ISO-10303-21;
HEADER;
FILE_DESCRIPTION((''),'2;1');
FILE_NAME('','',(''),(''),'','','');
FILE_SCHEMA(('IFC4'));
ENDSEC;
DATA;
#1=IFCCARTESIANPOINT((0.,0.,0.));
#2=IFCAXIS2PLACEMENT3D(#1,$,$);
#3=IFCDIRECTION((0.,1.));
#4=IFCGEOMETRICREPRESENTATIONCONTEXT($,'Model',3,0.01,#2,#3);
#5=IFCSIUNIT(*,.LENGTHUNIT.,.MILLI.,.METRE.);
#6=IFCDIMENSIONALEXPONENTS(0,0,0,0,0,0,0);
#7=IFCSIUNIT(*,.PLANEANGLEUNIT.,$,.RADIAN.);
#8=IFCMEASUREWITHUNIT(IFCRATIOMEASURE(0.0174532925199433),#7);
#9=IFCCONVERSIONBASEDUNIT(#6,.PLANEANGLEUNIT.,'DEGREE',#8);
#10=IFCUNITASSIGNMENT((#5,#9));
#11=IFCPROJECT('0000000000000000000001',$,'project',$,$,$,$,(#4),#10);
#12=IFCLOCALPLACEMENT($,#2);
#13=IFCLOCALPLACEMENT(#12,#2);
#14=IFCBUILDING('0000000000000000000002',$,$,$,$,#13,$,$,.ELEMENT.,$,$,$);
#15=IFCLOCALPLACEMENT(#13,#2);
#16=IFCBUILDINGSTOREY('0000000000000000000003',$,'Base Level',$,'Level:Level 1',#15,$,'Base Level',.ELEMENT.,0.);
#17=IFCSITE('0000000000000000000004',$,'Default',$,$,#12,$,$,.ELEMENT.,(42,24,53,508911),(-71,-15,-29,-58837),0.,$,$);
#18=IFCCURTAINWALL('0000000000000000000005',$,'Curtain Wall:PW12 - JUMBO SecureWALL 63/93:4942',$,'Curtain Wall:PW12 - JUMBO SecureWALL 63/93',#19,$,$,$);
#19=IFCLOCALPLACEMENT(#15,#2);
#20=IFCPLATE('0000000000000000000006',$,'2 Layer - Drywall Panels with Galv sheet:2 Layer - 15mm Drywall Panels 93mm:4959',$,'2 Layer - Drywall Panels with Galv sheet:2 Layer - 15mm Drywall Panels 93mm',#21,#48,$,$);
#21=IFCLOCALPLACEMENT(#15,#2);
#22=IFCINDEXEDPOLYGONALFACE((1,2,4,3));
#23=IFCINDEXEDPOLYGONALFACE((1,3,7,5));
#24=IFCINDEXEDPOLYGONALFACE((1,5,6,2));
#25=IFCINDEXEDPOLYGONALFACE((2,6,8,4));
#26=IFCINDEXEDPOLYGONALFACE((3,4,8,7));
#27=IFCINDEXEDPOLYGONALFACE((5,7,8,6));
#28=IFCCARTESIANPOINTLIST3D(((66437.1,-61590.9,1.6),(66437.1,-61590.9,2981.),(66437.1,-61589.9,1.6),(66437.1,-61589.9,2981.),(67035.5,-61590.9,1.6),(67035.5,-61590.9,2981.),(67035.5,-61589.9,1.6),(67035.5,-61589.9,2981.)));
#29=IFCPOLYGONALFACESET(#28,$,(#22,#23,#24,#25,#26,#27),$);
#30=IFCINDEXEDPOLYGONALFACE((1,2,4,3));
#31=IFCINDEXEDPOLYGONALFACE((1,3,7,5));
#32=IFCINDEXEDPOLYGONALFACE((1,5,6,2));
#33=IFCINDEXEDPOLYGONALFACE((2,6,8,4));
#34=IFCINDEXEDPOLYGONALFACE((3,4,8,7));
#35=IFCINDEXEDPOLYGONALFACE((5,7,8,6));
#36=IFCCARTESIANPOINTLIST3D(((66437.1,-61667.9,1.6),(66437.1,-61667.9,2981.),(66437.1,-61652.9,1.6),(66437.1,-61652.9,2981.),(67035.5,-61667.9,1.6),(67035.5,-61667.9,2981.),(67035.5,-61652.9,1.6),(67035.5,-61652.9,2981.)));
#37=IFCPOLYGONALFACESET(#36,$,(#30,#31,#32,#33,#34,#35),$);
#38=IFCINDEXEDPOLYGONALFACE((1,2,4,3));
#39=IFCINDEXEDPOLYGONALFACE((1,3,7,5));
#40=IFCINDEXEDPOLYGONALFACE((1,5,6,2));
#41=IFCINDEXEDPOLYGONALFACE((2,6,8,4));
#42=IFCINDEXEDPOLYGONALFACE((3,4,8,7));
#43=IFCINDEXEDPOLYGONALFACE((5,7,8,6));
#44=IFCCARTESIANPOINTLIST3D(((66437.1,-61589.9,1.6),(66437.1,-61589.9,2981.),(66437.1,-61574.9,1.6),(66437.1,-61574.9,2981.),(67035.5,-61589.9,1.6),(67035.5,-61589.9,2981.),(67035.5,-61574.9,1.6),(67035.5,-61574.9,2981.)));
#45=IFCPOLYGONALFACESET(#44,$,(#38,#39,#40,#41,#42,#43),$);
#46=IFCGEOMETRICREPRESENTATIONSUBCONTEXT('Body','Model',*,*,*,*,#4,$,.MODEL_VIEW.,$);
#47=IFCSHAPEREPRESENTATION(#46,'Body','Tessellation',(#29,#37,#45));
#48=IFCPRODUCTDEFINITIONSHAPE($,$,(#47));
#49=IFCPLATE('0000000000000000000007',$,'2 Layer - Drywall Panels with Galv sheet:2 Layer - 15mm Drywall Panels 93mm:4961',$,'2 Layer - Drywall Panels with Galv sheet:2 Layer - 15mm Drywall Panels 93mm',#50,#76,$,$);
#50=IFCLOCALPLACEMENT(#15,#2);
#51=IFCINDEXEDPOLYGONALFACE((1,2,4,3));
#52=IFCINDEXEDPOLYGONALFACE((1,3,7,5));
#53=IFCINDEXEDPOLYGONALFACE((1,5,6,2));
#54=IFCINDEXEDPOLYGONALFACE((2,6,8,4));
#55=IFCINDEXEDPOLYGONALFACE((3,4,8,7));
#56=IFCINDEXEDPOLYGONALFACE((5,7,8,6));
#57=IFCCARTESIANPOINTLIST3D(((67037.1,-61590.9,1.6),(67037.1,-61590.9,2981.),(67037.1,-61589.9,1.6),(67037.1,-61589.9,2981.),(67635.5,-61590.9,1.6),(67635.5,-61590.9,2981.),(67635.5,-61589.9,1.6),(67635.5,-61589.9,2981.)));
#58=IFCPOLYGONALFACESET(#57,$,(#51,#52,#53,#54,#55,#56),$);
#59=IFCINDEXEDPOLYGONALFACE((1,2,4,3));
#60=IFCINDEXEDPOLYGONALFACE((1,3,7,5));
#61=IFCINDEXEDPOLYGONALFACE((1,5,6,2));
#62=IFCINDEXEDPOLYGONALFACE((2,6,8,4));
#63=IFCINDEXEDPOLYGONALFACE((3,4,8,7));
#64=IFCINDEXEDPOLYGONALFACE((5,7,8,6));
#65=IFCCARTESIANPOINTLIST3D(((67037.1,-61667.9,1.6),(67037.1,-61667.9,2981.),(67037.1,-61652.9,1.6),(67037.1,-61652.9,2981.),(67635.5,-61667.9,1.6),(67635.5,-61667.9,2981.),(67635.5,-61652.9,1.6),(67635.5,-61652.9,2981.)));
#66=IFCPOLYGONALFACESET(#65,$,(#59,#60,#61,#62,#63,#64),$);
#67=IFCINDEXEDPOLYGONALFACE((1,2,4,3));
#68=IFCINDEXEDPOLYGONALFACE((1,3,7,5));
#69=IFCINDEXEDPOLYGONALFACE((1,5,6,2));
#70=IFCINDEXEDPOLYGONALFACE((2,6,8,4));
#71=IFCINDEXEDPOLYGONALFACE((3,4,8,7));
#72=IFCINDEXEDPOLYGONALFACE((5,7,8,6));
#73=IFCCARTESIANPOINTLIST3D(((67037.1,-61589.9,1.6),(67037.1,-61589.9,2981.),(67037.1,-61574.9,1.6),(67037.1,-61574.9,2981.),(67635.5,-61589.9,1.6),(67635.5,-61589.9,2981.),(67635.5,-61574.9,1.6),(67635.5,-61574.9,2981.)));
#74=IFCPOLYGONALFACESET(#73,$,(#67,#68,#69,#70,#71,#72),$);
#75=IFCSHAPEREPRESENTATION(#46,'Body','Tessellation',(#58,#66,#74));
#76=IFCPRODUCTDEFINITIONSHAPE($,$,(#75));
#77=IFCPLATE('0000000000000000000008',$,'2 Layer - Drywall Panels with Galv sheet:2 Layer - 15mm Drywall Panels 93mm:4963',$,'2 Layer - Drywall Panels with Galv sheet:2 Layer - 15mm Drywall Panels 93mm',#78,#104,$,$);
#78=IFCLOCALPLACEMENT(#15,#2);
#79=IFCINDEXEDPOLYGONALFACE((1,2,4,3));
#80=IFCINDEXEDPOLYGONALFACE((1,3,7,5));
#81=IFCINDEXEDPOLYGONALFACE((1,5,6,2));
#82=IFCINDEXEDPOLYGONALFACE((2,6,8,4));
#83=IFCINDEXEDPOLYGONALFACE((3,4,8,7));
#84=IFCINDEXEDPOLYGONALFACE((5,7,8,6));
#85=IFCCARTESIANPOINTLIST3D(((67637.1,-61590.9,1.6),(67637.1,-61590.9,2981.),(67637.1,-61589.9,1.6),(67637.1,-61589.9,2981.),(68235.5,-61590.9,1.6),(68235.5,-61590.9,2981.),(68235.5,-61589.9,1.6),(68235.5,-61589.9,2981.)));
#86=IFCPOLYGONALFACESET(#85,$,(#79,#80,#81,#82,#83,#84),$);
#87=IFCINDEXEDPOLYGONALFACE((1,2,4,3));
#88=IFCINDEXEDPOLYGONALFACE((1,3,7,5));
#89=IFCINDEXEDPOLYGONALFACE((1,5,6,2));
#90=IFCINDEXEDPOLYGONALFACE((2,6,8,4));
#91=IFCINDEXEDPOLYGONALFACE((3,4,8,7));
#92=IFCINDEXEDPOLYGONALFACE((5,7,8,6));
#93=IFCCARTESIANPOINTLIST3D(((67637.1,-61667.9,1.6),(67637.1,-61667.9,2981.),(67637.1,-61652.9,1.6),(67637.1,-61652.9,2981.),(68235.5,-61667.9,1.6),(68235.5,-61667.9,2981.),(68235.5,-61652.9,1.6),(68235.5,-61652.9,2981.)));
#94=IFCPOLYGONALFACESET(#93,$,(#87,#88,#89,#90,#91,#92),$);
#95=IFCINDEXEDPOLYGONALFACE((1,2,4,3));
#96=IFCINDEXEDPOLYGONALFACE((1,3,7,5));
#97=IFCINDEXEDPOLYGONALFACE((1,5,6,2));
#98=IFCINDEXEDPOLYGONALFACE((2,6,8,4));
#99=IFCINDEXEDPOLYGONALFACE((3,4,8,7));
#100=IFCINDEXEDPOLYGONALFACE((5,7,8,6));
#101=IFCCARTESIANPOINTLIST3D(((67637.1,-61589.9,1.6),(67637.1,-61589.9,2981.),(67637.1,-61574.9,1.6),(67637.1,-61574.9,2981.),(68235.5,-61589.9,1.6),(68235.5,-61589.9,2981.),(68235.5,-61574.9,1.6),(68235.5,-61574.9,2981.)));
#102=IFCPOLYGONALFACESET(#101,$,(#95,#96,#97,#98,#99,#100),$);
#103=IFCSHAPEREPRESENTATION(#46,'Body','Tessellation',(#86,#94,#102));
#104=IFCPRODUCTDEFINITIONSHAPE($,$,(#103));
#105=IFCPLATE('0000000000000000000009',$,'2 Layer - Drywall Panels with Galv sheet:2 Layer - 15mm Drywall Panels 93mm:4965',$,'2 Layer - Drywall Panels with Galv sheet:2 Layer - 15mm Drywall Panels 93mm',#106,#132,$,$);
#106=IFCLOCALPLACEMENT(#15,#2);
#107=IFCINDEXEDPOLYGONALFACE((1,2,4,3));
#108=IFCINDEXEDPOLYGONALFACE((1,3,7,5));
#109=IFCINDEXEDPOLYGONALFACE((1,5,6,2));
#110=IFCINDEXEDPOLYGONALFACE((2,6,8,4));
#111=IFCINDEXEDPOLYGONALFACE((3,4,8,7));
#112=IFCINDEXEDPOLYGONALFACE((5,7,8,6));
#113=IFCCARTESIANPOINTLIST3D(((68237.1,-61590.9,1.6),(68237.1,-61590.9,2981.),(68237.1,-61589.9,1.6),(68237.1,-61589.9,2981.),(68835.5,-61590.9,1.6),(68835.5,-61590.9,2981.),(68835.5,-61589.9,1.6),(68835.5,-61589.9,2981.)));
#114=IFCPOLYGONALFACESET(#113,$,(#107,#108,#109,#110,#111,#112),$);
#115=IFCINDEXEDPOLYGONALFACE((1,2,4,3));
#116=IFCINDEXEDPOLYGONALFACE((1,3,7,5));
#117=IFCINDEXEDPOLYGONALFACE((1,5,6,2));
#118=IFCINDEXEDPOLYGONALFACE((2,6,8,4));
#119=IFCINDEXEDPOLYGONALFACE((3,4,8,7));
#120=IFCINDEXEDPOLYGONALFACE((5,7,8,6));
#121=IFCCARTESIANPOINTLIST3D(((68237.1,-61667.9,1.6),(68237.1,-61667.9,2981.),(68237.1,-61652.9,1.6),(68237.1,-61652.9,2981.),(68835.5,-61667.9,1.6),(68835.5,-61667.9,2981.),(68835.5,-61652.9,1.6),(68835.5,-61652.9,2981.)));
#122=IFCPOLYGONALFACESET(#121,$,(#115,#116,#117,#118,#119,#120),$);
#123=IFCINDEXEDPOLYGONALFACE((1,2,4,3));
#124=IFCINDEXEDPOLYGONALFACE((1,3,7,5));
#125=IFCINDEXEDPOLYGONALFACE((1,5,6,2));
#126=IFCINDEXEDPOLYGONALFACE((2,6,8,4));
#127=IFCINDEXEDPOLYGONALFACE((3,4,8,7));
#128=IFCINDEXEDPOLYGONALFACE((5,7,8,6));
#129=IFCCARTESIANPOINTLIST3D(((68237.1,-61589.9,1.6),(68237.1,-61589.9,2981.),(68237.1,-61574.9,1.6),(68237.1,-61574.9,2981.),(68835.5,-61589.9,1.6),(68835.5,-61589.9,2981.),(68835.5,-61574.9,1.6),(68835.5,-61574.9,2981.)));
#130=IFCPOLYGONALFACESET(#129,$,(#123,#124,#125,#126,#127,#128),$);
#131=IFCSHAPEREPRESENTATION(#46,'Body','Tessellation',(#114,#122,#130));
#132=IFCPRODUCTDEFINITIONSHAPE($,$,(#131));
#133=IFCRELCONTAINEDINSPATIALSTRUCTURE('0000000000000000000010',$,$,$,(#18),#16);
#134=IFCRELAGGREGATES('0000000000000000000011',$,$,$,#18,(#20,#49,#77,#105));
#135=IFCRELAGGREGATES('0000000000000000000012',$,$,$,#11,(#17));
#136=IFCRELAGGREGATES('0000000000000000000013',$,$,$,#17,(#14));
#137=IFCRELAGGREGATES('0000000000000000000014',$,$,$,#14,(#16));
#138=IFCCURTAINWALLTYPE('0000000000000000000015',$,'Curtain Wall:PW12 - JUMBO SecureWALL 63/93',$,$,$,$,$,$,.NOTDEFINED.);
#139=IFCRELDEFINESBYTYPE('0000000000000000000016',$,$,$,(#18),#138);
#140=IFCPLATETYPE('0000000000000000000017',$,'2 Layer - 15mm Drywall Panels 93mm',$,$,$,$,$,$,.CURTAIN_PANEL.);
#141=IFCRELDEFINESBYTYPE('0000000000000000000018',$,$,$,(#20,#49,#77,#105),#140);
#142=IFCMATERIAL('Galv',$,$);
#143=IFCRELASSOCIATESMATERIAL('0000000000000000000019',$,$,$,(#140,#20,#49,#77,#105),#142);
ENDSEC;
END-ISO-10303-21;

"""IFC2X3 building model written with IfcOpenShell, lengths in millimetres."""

from ifc_helpers import new_model, entity, si_unit, converted_unit, direction, frame, frame_2d, origin, origin_2d_with_axis, place, context, subcontext, project, spatial, rectangle, extrude, source, transform, mapped, material, type_object, type_shapes, element, aggregate, save


model = new_model("IFC2X3")

# Units and contexts
model_context = context("Model", 3, precision=0.01, world=origin(), true_north=direction((0.0, 1.0)))
body_context = subcontext(model_context, "Body", "Model", "MODEL_VIEW")
ifc_project = project(units=[si_unit("LENGTHUNIT", "METRE", prefix="MILLI"), converted_unit("PLANEANGLEUNIT", "DEGREE", entity("IfcRatioMeasure", 0.0174532925199433), si_unit("PLANEANGLEUNIT", "RADIAN"), dimensions=[0, 0, 0, 0, 0, 0, 0])], contexts=[model_context])

# Site, building, storey
site_placement = place(None, origin())
site = spatial("IfcSite", under=ifc_project, at=site_placement, Name="Default", CompositionType="ELEMENT", RefLatitude=(42, 24, 53, 508911), RefLongitude=(-71, -15, -29, -58837), RefElevation=0.0)
building_placement = place(site_placement, origin())
building = spatial("IfcBuilding", under=site, at=building_placement, CompositionType="ELEMENT")
storey_placement = place(building_placement, origin())
storey = spatial("IfcBuildingStorey", under=building, at=storey_placement, Name="Base Level", ObjectType="Level:Level 1", LongName="Base Level", CompositionType="ELEMENT", Elevation=0.0)

# Curtain wall, plates
curtain_wall_type = type_object("IfcCurtainWallType", Name="Curtain Wall:PW12 - JUMBO SecureWALL 63/93", PredefinedType="NOTDEFINED")
curtain_wall_placement = place(building_placement, origin())
curtain_wall = element("IfcCurtainWall", 1, at=curtain_wall_placement, inside=storey, type_object=curtain_wall_type, Name="Curtain Wall:PW12 - JUMBO SecureWALL 63/93:4942", ObjectType="Curtain Wall:PW12 - JUMBO SecureWALL 63/93")
ifc_material_1 = material(Name="Galv")
plate_type = type_object("IfcPlateType", Name="2 Layer - 15mm Drywall Panels 93mm", PredefinedType="CURTAIN_PANEL", material=ifc_material_1)
shared_shape_1 = source(origin(), body_context, "Body", "SweptSolid", [
    extrude(rectangle(XDim=598.4, YDim=1.0, at=origin_2d_with_axis()), frame((0.0, 31.0, 0.0), z_axis=(0.0, 0.0, 1.0), x_axis=(-1.0, 0.0, 0.0)), (0.0, 0.0, 1.0), 2979.4),
    extrude(rectangle(XDim=598.4, YDim=15.0, at=frame_2d((0.0, 0.0), x_axis=(1.0, 0.0))), frame((0.0, -39.0, 0.0), z_axis=(0.0, 0.0, 1.0), x_axis=(-1.0, 0.0, 0.0)), (0.0, 0.0, 1.0), 2979.4),
    extrude(rectangle(XDim=15.0, YDim=598.4, at=frame_2d((0.0, 0.0), x_axis=(1.0, 0.0))), frame((0.0, 39.0, 0.0), z_axis=(0.0, 0.0, 1.0), x_axis=(0.0, 1.0, 0.0)), (0.0, 0.0, 1.0), 2979.4),
])
type_shapes(plate_type, [shared_shape_1])
plate_1_placement = place(curtain_wall_placement, frame((66736.3, -61621.4, 1.6)))
plate_1 = element("IfcPlate", 2, at=plate_1_placement, type_object=plate_type, material=ifc_material_1, Name="2 Layer - Drywall Panels with Galv sheet:2 Layer - 15mm Drywall Panels 93mm:4959", ObjectType="2 Layer - Drywall Panels with Galv sheet:2 Layer - 15mm Drywall Panels 93mm", context=body_context, shape_type="MappedRepresentation", body=[
    mapped(shared_shape_1, transform((0.0, 0.0, 0.0), scale=1.0)),
])
plate_2_placement = place(curtain_wall_placement, frame((67336.3, -61621.4, 1.6)))
plate_2 = element("IfcPlate", 3, at=plate_2_placement, type_object=plate_type, material=ifc_material_1, Name="2 Layer - Drywall Panels with Galv sheet:2 Layer - 15mm Drywall Panels 93mm:4961", ObjectType="2 Layer - Drywall Panels with Galv sheet:2 Layer - 15mm Drywall Panels 93mm", context=body_context, shape_type="MappedRepresentation", body=[
    mapped(shared_shape_1, transform((0.0, 0.0, 0.0), scale=1.0)),
])
plate_3_placement = place(curtain_wall_placement, frame((67936.3, -61621.4, 1.6)))
plate_3 = element("IfcPlate", 4, at=plate_3_placement, type_object=plate_type, material=ifc_material_1, Name="2 Layer - Drywall Panels with Galv sheet:2 Layer - 15mm Drywall Panels 93mm:4963", ObjectType="2 Layer - Drywall Panels with Galv sheet:2 Layer - 15mm Drywall Panels 93mm", context=body_context, shape_type="MappedRepresentation", body=[
    mapped(shared_shape_1, transform((0.0, 0.0, 0.0), scale=1.0)),
])
plate_4_placement = place(curtain_wall_placement, frame((68536.3, -61621.4, 1.6)))
plate_4 = element("IfcPlate", 5, at=plate_4_placement, type_object=plate_type, material=ifc_material_1, Name="2 Layer - Drywall Panels with Galv sheet:2 Layer - 15mm Drywall Panels 93mm:4965", ObjectType="2 Layer - Drywall Panels with Galv sheet:2 Layer - 15mm Drywall Panels 93mm", context=body_context, shape_type="MappedRepresentation", body=[
    mapped(shared_shape_1, transform((0.0, 0.0, 0.0), scale=1.0)),
])
aggregate(curtain_wall, [plate_1, plate_2, plate_3, plate_4])

save(model, "model.ifc")
